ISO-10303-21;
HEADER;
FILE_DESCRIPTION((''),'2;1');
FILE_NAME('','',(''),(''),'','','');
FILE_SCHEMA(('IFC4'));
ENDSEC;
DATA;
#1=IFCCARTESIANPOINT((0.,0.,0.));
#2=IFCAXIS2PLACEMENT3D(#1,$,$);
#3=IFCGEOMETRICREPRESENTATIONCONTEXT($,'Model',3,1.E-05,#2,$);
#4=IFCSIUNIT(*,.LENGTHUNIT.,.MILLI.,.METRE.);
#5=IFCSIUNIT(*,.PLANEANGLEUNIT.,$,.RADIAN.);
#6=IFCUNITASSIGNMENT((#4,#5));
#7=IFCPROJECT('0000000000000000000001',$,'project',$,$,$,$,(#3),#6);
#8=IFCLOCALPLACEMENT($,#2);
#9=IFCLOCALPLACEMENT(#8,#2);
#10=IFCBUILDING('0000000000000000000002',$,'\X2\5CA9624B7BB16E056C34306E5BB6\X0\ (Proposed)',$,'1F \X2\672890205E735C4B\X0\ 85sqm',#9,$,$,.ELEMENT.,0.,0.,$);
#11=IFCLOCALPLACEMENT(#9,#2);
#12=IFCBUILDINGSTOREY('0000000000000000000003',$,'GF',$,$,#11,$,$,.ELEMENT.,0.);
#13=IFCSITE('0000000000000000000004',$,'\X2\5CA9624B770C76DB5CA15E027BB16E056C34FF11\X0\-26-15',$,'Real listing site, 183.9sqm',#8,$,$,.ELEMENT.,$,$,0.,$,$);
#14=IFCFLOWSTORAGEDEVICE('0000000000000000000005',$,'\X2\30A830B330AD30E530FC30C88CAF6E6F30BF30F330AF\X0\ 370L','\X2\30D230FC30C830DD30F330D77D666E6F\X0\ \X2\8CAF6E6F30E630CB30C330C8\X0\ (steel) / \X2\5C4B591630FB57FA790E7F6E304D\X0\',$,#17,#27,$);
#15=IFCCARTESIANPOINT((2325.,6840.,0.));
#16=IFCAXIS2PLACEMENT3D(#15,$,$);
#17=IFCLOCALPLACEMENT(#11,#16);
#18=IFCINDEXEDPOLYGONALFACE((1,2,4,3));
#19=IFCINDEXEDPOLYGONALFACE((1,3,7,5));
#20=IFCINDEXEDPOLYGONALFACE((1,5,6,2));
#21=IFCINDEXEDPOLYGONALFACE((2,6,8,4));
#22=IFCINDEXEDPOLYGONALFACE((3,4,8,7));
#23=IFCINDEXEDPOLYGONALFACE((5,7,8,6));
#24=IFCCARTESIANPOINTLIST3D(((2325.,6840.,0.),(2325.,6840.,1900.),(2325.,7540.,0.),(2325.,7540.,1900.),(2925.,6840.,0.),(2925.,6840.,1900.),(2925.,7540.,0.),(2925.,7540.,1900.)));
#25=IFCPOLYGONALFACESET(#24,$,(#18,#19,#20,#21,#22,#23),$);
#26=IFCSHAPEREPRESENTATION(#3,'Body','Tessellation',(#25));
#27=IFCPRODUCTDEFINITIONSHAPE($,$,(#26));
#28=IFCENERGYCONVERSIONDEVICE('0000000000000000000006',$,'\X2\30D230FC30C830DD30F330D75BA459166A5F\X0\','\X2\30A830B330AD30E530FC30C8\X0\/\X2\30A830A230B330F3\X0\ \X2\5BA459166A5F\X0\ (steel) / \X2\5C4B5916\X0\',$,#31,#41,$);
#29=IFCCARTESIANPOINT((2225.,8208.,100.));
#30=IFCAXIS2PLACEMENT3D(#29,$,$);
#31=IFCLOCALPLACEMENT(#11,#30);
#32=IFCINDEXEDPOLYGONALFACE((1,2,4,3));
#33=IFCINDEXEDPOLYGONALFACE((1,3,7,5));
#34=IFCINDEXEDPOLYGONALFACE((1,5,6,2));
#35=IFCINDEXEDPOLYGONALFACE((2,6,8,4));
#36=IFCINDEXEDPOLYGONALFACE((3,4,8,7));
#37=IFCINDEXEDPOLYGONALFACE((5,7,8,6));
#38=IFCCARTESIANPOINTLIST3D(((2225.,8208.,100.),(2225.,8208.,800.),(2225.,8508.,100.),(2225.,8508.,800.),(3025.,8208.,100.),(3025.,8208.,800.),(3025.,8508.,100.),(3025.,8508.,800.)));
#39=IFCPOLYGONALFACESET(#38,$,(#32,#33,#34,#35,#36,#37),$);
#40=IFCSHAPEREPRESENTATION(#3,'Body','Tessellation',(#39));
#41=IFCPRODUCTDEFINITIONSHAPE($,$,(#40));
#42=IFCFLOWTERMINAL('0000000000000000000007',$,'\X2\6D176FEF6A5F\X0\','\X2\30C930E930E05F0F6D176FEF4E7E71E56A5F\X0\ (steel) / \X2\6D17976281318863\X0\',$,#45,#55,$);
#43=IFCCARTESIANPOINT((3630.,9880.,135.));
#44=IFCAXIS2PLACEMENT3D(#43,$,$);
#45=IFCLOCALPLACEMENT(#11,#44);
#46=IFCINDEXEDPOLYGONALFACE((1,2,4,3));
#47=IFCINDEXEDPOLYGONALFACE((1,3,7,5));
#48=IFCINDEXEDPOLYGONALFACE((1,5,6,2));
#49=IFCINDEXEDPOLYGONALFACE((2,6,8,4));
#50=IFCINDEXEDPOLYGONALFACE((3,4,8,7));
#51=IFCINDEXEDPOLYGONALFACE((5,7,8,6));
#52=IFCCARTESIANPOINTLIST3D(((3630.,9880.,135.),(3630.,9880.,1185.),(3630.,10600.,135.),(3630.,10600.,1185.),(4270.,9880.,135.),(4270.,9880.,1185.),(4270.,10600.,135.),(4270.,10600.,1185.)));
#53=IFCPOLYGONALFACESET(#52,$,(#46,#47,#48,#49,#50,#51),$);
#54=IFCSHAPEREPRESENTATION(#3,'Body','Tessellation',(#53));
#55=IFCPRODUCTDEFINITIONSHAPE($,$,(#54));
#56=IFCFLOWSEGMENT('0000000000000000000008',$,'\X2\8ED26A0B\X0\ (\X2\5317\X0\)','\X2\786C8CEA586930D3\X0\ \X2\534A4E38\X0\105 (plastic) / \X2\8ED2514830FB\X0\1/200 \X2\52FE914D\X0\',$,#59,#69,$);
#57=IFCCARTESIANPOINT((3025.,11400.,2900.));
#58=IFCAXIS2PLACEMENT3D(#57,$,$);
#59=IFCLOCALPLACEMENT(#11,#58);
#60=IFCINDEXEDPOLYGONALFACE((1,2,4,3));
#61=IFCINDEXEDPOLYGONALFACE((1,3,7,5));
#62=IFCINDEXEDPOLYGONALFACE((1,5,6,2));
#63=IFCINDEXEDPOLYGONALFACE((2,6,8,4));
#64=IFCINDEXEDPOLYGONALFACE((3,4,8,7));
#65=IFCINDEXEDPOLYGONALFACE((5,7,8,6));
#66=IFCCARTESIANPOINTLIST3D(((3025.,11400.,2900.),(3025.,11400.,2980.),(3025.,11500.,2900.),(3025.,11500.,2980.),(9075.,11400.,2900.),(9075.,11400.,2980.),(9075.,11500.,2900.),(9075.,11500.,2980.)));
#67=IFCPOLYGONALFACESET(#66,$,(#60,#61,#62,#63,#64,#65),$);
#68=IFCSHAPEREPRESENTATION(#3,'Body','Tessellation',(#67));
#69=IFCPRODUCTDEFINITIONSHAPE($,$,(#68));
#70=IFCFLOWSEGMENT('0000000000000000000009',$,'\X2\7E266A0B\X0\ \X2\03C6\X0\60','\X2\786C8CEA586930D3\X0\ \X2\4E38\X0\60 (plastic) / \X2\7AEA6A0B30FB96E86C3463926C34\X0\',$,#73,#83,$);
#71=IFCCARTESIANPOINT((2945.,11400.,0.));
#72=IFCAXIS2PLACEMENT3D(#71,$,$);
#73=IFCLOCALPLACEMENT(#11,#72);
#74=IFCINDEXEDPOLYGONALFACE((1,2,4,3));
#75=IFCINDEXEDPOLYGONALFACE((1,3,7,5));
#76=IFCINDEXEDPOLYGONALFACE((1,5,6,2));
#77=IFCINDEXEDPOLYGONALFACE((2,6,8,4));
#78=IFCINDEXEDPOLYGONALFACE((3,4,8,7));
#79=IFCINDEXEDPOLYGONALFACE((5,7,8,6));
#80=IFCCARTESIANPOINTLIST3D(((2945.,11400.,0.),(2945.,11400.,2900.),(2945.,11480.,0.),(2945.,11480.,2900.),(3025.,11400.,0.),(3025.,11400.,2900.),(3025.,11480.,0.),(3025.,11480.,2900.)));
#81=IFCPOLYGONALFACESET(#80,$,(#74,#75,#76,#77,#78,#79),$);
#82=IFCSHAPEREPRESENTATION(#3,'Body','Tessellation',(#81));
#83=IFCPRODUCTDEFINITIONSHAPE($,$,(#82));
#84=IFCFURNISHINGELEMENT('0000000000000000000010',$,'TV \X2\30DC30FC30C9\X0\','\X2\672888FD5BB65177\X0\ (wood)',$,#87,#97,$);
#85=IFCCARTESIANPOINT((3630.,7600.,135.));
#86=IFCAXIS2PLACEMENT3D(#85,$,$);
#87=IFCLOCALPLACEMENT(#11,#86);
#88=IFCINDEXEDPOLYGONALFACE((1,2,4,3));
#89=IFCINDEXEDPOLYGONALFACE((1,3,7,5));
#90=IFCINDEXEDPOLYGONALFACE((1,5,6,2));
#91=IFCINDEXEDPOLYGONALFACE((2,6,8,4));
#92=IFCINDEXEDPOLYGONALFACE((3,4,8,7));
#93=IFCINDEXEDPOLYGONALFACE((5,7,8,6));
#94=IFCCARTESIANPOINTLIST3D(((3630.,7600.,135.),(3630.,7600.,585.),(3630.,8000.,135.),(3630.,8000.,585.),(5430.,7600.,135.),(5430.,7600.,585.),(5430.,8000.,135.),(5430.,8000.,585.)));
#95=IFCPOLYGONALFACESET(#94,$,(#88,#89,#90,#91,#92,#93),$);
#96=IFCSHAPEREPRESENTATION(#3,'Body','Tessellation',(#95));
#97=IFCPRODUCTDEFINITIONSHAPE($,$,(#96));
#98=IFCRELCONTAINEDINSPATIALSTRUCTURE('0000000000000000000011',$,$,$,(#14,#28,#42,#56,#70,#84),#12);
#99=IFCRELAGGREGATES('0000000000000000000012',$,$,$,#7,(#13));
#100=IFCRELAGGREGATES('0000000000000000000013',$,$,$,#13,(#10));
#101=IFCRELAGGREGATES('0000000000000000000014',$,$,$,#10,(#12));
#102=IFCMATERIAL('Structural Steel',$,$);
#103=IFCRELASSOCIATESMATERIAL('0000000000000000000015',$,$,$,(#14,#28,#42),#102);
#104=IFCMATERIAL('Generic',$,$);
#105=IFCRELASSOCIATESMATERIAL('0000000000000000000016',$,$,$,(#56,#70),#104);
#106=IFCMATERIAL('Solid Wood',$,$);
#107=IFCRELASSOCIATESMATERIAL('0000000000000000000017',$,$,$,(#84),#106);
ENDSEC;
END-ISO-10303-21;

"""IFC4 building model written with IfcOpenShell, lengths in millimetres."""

from ifc_helpers import new_model, si_unit, frame, frame_2d, origin, place, context, project, spatial, rectangle, extrude, material, element, save


model = new_model("IFC4")

# Units and contexts
model_context = context("Model", 3, precision=1e-05, world=origin())
ifc_project = project(units=[si_unit("LENGTHUNIT", "METRE", prefix="MILLI"), si_unit("PLANEANGLEUNIT", "RADIAN")], contexts=[model_context])

# Site, building, storey
site_placement = place(None, origin())
site = spatial("IfcSite", under=ifc_project, at=site_placement, Name="岩手県盛岡市箱清水１-26-15", ObjectType="Real listing site, 183.9sqm", CompositionType="ELEMENT", RefElevation=0.0)
building_placement = place(site_placement, origin())
building = spatial("IfcBuilding", under=site, at=building_placement, Name="岩手箱清水の家 (Proposed)", ObjectType="1F 木造平屋 85sqm", CompositionType="ELEMENT", ElevationOfRefHeight=0.0, ElevationOfTerrain=0.0)
storey_placement = place(building_placement, origin())
storey = spatial("IfcBuildingStorey", under=building, at=storey_placement, Name="GF", CompositionType="ELEMENT", Elevation=0.0)

# Shared definitions
ifc_material_1 = material(Name="Solid Wood")

# Shared definitions
ifc_material_2 = material(Name="Structural Steel")

# Shared definitions
ifc_material_3 = material(Name="Generic")

# Flow storage device
flow_storage_device_placement = place(storey_placement, frame((2325.0, 6840.0, 0.0)))
element("IfcFlowStorageDevice", 1, at=flow_storage_device_placement, inside=storey, material=ifc_material_2, Name="エコキュート貯湯タンク 370L", Description="ヒートポンプ給湯 貯湯ユニット (steel) / 屋外・基礎置き", context=model_context, shape_type="SweptSolid", body=[
    extrude(rectangle(XDim=600.0, YDim=700.0, at=frame_2d((300.0, 350.0))), frame((2325.0, 6840.0, 0.0)), (0.0, 0.0, 1.0), 1900.0),
])

# Energy conversion device
energy_conversion_device_placement = place(storey_placement, frame((2225.0, 8208.0, 100.0)))
element("IfcEnergyConversionDevice", 2, at=energy_conversion_device_placement, inside=storey, material=ifc_material_2, Name="ヒートポンプ室外機", Description="エコキュート/エアコン 室外機 (steel) / 屋外", context=model_context, shape_type="SweptSolid", body=[
    extrude(rectangle(XDim=800.0, YDim=300.0, at=frame_2d((400.0, 150.0))), frame((2225.0, 8208.0, 100.0)), (0.0, 0.0, 1.0), 700.0),
])

# Flow terminal
flow_terminal_placement = place(storey_placement, frame((3630.0, 9880.0, 135.0)))
element("IfcFlowTerminal", 3, at=flow_terminal_placement, inside=storey, material=ifc_material_2, Name="洗濯機", Description="ドラム式洗濯乾燥機 (steel) / 洗面脱衣", context=model_context, shape_type="SweptSolid", body=[
    extrude(rectangle(XDim=640.0, YDim=720.0, at=frame_2d((320.0, 360.0))), frame((3630.0, 9880.0, 135.0)), (0.0, 0.0, 1.0), 1050.0),
])

# Flow segments
flow_segment_1_placement = place(storey_placement, frame((3025.0, 11400.0, 2900.0)))
element("IfcFlowSegment", 4, at=flow_segment_1_placement, inside=storey, material=ifc_material_3, Name="軒樋 (北)", Description="硬質塩ビ 半丸105 (plastic) / 軒先・1/200 勾配", context=model_context, shape_type="SweptSolid", body=[
    extrude(rectangle(XDim=6050.0, YDim=100.0, at=frame_2d((3025.0, 50.0))), frame((3025.0, 11400.0, 2900.0)), (0.0, 0.0, 1.0), 80.0),
])
flow_segment_2_placement = place(storey_placement, frame((2945.0, 11400.0, 0.0)))
element("IfcFlowSegment", 5, at=flow_segment_2_placement, inside=storey, material=ifc_material_3, Name="縦樋 φ60", Description="硬質塩ビ 丸60 (plastic) / 竪樋・雨水排水", context=model_context, shape_type="SweptSolid", body=[
    extrude(rectangle(XDim=80.0, YDim=80.0, at=frame_2d((40.0, 40.0))), frame((2945.0, 11400.0, 0.0)), (0.0, 0.0, 1.0), 2900.0),
])

# Furnishing element
furnishing_placement = place(storey_placement, frame((3630.0, 7600.0, 135.0)))
element("IfcFurnishingElement", 6, at=furnishing_placement, inside=storey, material=ifc_material_1, Name="TV ボード", Description="木製家具 (wood)", context=model_context, shape_type="SweptSolid", body=[
    extrude(rectangle(XDim=1800.0, YDim=400.0, at=frame_2d((900.0, 200.0))), frame((3630.0, 7600.0, 135.0)), (0.0, 0.0, 1.0), 450.0),
])

save(model, "model.ifc")
